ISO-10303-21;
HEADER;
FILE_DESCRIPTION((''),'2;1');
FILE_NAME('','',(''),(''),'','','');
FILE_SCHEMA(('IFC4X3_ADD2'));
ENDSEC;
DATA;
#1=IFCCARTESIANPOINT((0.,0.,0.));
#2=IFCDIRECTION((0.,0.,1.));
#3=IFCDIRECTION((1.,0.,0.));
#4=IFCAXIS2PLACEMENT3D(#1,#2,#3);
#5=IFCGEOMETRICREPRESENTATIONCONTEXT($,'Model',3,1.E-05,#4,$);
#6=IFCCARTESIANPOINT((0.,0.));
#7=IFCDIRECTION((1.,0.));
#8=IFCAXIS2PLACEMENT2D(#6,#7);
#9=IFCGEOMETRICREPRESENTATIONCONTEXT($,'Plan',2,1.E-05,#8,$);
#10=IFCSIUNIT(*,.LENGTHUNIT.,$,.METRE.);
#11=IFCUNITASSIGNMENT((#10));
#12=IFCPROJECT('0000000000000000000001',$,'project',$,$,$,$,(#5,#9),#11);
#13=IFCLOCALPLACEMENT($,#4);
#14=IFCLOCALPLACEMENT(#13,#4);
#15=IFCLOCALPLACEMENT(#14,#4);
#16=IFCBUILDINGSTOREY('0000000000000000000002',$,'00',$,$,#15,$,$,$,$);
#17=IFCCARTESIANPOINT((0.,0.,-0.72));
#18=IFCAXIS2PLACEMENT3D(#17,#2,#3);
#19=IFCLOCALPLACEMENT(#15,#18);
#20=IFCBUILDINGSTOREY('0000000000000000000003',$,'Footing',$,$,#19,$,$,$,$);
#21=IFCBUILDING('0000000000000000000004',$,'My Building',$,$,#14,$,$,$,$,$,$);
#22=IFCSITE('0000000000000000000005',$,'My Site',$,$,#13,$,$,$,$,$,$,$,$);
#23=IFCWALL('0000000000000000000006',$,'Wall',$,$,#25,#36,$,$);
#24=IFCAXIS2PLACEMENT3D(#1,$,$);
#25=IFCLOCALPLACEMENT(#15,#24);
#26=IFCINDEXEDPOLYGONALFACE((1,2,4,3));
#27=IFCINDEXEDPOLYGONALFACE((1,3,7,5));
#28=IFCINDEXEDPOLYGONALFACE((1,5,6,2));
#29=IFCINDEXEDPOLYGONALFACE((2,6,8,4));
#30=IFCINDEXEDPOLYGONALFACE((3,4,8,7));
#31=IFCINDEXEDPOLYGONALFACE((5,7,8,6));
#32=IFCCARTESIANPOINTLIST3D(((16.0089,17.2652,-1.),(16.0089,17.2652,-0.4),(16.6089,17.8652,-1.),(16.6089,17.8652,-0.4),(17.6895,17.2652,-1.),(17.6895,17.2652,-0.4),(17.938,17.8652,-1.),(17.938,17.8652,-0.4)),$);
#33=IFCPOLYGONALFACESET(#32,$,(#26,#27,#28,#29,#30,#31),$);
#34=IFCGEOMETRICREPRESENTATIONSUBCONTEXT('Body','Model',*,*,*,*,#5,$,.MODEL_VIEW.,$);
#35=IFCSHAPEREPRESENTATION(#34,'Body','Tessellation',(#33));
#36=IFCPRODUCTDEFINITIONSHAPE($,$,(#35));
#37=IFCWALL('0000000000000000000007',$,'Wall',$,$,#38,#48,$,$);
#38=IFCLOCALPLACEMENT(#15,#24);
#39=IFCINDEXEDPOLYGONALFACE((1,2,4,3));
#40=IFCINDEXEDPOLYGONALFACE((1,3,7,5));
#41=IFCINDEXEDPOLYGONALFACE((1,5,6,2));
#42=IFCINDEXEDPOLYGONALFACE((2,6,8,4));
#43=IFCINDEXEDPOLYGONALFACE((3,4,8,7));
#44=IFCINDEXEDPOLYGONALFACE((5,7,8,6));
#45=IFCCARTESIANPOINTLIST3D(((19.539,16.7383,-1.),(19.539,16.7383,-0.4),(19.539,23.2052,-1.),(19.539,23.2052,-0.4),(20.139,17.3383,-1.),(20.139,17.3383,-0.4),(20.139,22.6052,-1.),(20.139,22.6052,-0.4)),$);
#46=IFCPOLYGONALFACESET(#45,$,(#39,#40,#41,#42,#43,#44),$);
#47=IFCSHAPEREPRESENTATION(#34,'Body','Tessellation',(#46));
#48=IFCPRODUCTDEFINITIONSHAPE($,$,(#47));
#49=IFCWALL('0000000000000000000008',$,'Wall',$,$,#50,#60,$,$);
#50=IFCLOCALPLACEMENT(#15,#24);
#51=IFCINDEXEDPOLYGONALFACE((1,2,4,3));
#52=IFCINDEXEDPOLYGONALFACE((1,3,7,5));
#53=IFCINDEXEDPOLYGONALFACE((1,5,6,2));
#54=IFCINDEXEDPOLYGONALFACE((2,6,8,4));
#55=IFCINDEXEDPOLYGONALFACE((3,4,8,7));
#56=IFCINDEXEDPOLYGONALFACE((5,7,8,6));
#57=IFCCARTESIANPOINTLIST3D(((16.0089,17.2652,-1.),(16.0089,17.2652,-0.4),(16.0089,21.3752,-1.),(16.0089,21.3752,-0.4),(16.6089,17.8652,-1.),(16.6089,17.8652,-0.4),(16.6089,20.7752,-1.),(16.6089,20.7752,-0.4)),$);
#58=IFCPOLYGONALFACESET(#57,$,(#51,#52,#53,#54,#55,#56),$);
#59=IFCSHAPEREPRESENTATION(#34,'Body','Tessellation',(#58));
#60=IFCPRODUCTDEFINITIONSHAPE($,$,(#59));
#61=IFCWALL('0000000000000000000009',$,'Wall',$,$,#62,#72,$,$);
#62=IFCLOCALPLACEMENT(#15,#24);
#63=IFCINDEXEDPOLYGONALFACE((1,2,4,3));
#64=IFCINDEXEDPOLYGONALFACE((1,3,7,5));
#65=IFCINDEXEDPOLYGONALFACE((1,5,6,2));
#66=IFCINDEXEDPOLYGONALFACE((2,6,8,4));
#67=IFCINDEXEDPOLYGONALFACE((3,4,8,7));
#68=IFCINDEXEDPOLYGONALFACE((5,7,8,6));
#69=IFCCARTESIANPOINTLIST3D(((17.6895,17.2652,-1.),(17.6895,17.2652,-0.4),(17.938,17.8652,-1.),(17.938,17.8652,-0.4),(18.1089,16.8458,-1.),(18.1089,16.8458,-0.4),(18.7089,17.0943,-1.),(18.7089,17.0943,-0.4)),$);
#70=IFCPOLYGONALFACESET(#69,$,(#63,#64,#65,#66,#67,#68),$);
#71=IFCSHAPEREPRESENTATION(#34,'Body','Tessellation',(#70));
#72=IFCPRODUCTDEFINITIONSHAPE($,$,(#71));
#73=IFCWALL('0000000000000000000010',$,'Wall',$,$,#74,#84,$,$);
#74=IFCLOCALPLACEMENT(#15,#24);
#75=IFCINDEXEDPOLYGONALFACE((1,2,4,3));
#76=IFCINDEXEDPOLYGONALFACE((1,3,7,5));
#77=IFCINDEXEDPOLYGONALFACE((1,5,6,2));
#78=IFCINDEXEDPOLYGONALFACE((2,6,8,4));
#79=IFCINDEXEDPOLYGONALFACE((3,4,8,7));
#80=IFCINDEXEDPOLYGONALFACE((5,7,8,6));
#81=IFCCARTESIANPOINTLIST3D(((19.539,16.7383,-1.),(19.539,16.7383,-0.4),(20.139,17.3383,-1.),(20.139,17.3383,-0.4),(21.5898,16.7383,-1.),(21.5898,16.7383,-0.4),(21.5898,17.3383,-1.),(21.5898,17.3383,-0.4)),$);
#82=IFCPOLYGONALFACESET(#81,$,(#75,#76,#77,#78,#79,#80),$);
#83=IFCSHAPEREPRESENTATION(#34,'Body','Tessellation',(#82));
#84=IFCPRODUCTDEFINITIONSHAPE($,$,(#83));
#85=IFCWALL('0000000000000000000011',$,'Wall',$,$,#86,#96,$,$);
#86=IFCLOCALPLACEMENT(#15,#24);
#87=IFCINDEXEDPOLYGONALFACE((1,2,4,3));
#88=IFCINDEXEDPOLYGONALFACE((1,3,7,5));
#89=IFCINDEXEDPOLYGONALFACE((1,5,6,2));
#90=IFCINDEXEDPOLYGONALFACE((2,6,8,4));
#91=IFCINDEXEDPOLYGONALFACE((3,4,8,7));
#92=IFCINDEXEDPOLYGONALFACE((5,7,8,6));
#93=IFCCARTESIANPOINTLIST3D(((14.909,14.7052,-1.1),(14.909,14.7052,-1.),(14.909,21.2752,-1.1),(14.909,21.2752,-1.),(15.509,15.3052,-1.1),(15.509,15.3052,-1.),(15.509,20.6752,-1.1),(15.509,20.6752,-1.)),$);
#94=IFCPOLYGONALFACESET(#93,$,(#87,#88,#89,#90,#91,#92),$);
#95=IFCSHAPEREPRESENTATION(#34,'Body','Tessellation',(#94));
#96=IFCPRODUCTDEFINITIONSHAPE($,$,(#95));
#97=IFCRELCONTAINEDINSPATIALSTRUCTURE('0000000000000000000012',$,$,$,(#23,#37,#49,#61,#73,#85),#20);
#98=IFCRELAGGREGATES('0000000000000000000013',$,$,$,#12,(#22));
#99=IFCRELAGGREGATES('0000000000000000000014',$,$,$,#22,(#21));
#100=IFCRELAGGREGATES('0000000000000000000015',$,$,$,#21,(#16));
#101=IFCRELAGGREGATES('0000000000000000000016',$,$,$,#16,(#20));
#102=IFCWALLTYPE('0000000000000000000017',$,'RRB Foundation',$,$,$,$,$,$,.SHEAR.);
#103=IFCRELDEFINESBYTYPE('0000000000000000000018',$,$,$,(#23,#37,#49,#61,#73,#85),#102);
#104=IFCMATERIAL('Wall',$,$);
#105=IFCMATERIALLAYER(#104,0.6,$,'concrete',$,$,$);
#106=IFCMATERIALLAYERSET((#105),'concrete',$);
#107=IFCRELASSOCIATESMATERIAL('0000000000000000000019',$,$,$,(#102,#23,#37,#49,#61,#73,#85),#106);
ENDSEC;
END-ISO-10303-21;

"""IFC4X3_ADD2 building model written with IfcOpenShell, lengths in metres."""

from ifc_helpers import new_model, si_unit, frame, origin_with_axes, origin_2d_with_axis, place, context, subcontext, project, spatial, line, indexed_curve, outline, extrude, material, layer, layer_set, layer_usage, type_object, element, save


model = new_model("IFC4X3_ADD2")

# Units and contexts
model_context = context("Model", 3, precision=1e-05, world=origin_with_axes())
plan_context = context("Plan", 2, precision=1e-05, world=origin_2d_with_axis())
body_context = subcontext(model_context, "Body", "Model", "MODEL_VIEW")
ifc_project = project(units=[si_unit("LENGTHUNIT", "METRE")], contexts=[model_context, plan_context])

# Site, building, storeys
site_placement = place(None, origin_with_axes())
site = spatial("IfcSite", under=ifc_project, at=site_placement, Name="My Site")
building_placement = place(site_placement, origin_with_axes())
building = spatial("IfcBuilding", under=site, at=building_placement, Name="My Building")
storey_1_placement = place(building_placement, origin_with_axes())
storey_1 = spatial("IfcBuildingStorey", under=building, at=storey_1_placement, Name="00")
storey_2_placement = place(storey_1_placement, frame((0.0, 0.0, -0.72), z_axis=(0.0, 0.0, 1.0), x_axis=(1.0, 0.0, 0.0)))
storey_2 = spatial("IfcBuildingStorey", under=storey_1, at=storey_2_placement, Name="Footing")

# Walls
ifc_material_1 = material(Name="Wall")
ifc_layer_1 = layer(ifc_material_1, 0.6, Name="concrete")
ifc_layer_set_1 = layer_set([ifc_layer_1], Name="concrete")
ifc_layer_usage_1 = layer_usage(ifc_layer_set_1, "AXIS2", "POSITIVE", 0.0)
wall_type_1 = type_object("IfcWallType", Name="RRB Foundation", PredefinedType="SHEAR", material=ifc_layer_set_1)
wall_1_placement = place(storey_2_placement, frame((16.6089, 17.2652, -0.28), z_axis=(0.0, 0.0, 1.0), x_axis=(1.0, 0.0, 0.0)))
element("IfcWall", 1, at=wall_1_placement, inside=storey_2, type_object=wall_type_1, material=ifc_layer_usage_1, Name="Wall", context=body_context, shape_type="SweptSolid", body=[
    extrude(outline(indexed_curve([(-0.6, 0.0), (0.0, 0.6), (1.3291, 0.6), (1.0806, 0.0)], segments=[line(1, 2, 3, 4, 1)])), origin_with_axes(), (0.0, 0.0, 1.0), 0.6),
])
ifc_layer_usage_2 = layer_usage(ifc_layer_set_1, "AXIS2", "POSITIVE", 0.0)
wall_2_placement = place(storey_2_placement, frame((20.139, 16.7383, -0.28), z_axis=(0.0, 0.0, 1.0), x_axis=(0.000001, 1.0, 0.0)))
element("IfcWall", 2, at=wall_2_placement, inside=storey_2, type_object=wall_type_1, material=ifc_layer_usage_2, Name="Wall", context=body_context, shape_type="SweptSolid", body=[
    extrude(outline(indexed_curve([(0.6, 0.0), (0.0, 0.6), (6.4669, 0.6), (5.8669, 0.0)], segments=[line(1, 2, 3, 4, 1)])), origin_with_axes(), (0.0, 0.0, 1.0), 0.6),
])
ifc_layer_usage_3 = layer_usage(ifc_layer_set_1, "AXIS2", "POSITIVE", 0.0)
wall_3_placement = place(storey_2_placement, frame((16.6089, 17.2652, -0.28), z_axis=(0.0, 0.0, 1.0), x_axis=(0.000001, 1.0, 0.0)))
element("IfcWall", 3, at=wall_3_placement, inside=storey_2, type_object=wall_type_1, material=ifc_layer_usage_3, Name="Wall", context=body_context, shape_type="SweptSolid", body=[
    extrude(outline(indexed_curve([(0.6, 0.0), (0.0, 0.6), (4.11, 0.6), (3.51, 0.0)], segments=[line(1, 2, 3, 4, 1)])), origin_with_axes(), (0.0, 0.0, 1.0), 0.6),
])
ifc_layer_usage_4 = layer_usage(ifc_layer_set_1, "AXIS2", "POSITIVE", 0.0)
wall_4_placement = place(storey_2_placement, frame((18.7089, 17.0943, -0.28), z_axis=(0.0, 0.0, 1.0), x_axis=(-0.707107, 0.707107, 0.0)))
element("IfcWall", 4, at=wall_4_placement, inside=storey_2, type_object=wall_type_1, material=ifc_layer_usage_4, Name="Wall", context=body_context, shape_type="SweptSolid", body=[
    extrude(outline(indexed_curve([(0.0, 0.0), (0.2485, 0.6), (0.8417, 0.6), (1.0902, 0.0)], segments=[line(1, 2, 3, 4, 1)])), origin_with_axes(), (0.0, 0.0, 1.0), 0.6),
])
ifc_layer_usage_5 = layer_usage(ifc_layer_set_1, "AXIS2", "POSITIVE", 0.0)
wall_5_placement = place(storey_2_placement, frame((20.139, 16.7383, -0.28), z_axis=(0.0, 0.0, 1.0), x_axis=(1.0, 0.0, 0.0)))
element("IfcWall", 5, at=wall_5_placement, inside=storey_2, type_object=wall_type_1, material=ifc_layer_usage_5, Name="Wall", context=body_context, shape_type="SweptSolid", body=[
    extrude(outline(indexed_curve([(-0.6, 0.0), (0.0, 0.6), (1.4508, 0.6), (1.4508, 0.0)], segments=[line(1, 2, 3, 4, 1)])), origin_with_axes(), (0.0, 0.0, 1.0), 0.6),
])
ifc_layer_usage_6 = layer_usage(ifc_layer_set_1, "AXIS2", "POSITIVE", 0.0)
wall_6_placement = place(storey_2_placement, frame((15.509, 15.3052, -0.38), z_axis=(0.0, 0.0, 1.0), x_axis=(0.000001, 1.0, 0.0)))
element("IfcWall", 6, at=wall_6_placement, inside=storey_2, type_object=wall_type_1, material=ifc_layer_usage_6, Name="Wall", context=body_context, shape_type="SweptSolid", body=[
    extrude(outline(indexed_curve([(0.0, 0.0), (-0.6, 0.6), (5.97, 0.6), (5.37, 0.0)], segments=[line(1, 2, 3, 4, 1)])), origin_with_axes(), (0.0, 0.0, 1.0), 0.1),
])

save(model, "model.ifc")
